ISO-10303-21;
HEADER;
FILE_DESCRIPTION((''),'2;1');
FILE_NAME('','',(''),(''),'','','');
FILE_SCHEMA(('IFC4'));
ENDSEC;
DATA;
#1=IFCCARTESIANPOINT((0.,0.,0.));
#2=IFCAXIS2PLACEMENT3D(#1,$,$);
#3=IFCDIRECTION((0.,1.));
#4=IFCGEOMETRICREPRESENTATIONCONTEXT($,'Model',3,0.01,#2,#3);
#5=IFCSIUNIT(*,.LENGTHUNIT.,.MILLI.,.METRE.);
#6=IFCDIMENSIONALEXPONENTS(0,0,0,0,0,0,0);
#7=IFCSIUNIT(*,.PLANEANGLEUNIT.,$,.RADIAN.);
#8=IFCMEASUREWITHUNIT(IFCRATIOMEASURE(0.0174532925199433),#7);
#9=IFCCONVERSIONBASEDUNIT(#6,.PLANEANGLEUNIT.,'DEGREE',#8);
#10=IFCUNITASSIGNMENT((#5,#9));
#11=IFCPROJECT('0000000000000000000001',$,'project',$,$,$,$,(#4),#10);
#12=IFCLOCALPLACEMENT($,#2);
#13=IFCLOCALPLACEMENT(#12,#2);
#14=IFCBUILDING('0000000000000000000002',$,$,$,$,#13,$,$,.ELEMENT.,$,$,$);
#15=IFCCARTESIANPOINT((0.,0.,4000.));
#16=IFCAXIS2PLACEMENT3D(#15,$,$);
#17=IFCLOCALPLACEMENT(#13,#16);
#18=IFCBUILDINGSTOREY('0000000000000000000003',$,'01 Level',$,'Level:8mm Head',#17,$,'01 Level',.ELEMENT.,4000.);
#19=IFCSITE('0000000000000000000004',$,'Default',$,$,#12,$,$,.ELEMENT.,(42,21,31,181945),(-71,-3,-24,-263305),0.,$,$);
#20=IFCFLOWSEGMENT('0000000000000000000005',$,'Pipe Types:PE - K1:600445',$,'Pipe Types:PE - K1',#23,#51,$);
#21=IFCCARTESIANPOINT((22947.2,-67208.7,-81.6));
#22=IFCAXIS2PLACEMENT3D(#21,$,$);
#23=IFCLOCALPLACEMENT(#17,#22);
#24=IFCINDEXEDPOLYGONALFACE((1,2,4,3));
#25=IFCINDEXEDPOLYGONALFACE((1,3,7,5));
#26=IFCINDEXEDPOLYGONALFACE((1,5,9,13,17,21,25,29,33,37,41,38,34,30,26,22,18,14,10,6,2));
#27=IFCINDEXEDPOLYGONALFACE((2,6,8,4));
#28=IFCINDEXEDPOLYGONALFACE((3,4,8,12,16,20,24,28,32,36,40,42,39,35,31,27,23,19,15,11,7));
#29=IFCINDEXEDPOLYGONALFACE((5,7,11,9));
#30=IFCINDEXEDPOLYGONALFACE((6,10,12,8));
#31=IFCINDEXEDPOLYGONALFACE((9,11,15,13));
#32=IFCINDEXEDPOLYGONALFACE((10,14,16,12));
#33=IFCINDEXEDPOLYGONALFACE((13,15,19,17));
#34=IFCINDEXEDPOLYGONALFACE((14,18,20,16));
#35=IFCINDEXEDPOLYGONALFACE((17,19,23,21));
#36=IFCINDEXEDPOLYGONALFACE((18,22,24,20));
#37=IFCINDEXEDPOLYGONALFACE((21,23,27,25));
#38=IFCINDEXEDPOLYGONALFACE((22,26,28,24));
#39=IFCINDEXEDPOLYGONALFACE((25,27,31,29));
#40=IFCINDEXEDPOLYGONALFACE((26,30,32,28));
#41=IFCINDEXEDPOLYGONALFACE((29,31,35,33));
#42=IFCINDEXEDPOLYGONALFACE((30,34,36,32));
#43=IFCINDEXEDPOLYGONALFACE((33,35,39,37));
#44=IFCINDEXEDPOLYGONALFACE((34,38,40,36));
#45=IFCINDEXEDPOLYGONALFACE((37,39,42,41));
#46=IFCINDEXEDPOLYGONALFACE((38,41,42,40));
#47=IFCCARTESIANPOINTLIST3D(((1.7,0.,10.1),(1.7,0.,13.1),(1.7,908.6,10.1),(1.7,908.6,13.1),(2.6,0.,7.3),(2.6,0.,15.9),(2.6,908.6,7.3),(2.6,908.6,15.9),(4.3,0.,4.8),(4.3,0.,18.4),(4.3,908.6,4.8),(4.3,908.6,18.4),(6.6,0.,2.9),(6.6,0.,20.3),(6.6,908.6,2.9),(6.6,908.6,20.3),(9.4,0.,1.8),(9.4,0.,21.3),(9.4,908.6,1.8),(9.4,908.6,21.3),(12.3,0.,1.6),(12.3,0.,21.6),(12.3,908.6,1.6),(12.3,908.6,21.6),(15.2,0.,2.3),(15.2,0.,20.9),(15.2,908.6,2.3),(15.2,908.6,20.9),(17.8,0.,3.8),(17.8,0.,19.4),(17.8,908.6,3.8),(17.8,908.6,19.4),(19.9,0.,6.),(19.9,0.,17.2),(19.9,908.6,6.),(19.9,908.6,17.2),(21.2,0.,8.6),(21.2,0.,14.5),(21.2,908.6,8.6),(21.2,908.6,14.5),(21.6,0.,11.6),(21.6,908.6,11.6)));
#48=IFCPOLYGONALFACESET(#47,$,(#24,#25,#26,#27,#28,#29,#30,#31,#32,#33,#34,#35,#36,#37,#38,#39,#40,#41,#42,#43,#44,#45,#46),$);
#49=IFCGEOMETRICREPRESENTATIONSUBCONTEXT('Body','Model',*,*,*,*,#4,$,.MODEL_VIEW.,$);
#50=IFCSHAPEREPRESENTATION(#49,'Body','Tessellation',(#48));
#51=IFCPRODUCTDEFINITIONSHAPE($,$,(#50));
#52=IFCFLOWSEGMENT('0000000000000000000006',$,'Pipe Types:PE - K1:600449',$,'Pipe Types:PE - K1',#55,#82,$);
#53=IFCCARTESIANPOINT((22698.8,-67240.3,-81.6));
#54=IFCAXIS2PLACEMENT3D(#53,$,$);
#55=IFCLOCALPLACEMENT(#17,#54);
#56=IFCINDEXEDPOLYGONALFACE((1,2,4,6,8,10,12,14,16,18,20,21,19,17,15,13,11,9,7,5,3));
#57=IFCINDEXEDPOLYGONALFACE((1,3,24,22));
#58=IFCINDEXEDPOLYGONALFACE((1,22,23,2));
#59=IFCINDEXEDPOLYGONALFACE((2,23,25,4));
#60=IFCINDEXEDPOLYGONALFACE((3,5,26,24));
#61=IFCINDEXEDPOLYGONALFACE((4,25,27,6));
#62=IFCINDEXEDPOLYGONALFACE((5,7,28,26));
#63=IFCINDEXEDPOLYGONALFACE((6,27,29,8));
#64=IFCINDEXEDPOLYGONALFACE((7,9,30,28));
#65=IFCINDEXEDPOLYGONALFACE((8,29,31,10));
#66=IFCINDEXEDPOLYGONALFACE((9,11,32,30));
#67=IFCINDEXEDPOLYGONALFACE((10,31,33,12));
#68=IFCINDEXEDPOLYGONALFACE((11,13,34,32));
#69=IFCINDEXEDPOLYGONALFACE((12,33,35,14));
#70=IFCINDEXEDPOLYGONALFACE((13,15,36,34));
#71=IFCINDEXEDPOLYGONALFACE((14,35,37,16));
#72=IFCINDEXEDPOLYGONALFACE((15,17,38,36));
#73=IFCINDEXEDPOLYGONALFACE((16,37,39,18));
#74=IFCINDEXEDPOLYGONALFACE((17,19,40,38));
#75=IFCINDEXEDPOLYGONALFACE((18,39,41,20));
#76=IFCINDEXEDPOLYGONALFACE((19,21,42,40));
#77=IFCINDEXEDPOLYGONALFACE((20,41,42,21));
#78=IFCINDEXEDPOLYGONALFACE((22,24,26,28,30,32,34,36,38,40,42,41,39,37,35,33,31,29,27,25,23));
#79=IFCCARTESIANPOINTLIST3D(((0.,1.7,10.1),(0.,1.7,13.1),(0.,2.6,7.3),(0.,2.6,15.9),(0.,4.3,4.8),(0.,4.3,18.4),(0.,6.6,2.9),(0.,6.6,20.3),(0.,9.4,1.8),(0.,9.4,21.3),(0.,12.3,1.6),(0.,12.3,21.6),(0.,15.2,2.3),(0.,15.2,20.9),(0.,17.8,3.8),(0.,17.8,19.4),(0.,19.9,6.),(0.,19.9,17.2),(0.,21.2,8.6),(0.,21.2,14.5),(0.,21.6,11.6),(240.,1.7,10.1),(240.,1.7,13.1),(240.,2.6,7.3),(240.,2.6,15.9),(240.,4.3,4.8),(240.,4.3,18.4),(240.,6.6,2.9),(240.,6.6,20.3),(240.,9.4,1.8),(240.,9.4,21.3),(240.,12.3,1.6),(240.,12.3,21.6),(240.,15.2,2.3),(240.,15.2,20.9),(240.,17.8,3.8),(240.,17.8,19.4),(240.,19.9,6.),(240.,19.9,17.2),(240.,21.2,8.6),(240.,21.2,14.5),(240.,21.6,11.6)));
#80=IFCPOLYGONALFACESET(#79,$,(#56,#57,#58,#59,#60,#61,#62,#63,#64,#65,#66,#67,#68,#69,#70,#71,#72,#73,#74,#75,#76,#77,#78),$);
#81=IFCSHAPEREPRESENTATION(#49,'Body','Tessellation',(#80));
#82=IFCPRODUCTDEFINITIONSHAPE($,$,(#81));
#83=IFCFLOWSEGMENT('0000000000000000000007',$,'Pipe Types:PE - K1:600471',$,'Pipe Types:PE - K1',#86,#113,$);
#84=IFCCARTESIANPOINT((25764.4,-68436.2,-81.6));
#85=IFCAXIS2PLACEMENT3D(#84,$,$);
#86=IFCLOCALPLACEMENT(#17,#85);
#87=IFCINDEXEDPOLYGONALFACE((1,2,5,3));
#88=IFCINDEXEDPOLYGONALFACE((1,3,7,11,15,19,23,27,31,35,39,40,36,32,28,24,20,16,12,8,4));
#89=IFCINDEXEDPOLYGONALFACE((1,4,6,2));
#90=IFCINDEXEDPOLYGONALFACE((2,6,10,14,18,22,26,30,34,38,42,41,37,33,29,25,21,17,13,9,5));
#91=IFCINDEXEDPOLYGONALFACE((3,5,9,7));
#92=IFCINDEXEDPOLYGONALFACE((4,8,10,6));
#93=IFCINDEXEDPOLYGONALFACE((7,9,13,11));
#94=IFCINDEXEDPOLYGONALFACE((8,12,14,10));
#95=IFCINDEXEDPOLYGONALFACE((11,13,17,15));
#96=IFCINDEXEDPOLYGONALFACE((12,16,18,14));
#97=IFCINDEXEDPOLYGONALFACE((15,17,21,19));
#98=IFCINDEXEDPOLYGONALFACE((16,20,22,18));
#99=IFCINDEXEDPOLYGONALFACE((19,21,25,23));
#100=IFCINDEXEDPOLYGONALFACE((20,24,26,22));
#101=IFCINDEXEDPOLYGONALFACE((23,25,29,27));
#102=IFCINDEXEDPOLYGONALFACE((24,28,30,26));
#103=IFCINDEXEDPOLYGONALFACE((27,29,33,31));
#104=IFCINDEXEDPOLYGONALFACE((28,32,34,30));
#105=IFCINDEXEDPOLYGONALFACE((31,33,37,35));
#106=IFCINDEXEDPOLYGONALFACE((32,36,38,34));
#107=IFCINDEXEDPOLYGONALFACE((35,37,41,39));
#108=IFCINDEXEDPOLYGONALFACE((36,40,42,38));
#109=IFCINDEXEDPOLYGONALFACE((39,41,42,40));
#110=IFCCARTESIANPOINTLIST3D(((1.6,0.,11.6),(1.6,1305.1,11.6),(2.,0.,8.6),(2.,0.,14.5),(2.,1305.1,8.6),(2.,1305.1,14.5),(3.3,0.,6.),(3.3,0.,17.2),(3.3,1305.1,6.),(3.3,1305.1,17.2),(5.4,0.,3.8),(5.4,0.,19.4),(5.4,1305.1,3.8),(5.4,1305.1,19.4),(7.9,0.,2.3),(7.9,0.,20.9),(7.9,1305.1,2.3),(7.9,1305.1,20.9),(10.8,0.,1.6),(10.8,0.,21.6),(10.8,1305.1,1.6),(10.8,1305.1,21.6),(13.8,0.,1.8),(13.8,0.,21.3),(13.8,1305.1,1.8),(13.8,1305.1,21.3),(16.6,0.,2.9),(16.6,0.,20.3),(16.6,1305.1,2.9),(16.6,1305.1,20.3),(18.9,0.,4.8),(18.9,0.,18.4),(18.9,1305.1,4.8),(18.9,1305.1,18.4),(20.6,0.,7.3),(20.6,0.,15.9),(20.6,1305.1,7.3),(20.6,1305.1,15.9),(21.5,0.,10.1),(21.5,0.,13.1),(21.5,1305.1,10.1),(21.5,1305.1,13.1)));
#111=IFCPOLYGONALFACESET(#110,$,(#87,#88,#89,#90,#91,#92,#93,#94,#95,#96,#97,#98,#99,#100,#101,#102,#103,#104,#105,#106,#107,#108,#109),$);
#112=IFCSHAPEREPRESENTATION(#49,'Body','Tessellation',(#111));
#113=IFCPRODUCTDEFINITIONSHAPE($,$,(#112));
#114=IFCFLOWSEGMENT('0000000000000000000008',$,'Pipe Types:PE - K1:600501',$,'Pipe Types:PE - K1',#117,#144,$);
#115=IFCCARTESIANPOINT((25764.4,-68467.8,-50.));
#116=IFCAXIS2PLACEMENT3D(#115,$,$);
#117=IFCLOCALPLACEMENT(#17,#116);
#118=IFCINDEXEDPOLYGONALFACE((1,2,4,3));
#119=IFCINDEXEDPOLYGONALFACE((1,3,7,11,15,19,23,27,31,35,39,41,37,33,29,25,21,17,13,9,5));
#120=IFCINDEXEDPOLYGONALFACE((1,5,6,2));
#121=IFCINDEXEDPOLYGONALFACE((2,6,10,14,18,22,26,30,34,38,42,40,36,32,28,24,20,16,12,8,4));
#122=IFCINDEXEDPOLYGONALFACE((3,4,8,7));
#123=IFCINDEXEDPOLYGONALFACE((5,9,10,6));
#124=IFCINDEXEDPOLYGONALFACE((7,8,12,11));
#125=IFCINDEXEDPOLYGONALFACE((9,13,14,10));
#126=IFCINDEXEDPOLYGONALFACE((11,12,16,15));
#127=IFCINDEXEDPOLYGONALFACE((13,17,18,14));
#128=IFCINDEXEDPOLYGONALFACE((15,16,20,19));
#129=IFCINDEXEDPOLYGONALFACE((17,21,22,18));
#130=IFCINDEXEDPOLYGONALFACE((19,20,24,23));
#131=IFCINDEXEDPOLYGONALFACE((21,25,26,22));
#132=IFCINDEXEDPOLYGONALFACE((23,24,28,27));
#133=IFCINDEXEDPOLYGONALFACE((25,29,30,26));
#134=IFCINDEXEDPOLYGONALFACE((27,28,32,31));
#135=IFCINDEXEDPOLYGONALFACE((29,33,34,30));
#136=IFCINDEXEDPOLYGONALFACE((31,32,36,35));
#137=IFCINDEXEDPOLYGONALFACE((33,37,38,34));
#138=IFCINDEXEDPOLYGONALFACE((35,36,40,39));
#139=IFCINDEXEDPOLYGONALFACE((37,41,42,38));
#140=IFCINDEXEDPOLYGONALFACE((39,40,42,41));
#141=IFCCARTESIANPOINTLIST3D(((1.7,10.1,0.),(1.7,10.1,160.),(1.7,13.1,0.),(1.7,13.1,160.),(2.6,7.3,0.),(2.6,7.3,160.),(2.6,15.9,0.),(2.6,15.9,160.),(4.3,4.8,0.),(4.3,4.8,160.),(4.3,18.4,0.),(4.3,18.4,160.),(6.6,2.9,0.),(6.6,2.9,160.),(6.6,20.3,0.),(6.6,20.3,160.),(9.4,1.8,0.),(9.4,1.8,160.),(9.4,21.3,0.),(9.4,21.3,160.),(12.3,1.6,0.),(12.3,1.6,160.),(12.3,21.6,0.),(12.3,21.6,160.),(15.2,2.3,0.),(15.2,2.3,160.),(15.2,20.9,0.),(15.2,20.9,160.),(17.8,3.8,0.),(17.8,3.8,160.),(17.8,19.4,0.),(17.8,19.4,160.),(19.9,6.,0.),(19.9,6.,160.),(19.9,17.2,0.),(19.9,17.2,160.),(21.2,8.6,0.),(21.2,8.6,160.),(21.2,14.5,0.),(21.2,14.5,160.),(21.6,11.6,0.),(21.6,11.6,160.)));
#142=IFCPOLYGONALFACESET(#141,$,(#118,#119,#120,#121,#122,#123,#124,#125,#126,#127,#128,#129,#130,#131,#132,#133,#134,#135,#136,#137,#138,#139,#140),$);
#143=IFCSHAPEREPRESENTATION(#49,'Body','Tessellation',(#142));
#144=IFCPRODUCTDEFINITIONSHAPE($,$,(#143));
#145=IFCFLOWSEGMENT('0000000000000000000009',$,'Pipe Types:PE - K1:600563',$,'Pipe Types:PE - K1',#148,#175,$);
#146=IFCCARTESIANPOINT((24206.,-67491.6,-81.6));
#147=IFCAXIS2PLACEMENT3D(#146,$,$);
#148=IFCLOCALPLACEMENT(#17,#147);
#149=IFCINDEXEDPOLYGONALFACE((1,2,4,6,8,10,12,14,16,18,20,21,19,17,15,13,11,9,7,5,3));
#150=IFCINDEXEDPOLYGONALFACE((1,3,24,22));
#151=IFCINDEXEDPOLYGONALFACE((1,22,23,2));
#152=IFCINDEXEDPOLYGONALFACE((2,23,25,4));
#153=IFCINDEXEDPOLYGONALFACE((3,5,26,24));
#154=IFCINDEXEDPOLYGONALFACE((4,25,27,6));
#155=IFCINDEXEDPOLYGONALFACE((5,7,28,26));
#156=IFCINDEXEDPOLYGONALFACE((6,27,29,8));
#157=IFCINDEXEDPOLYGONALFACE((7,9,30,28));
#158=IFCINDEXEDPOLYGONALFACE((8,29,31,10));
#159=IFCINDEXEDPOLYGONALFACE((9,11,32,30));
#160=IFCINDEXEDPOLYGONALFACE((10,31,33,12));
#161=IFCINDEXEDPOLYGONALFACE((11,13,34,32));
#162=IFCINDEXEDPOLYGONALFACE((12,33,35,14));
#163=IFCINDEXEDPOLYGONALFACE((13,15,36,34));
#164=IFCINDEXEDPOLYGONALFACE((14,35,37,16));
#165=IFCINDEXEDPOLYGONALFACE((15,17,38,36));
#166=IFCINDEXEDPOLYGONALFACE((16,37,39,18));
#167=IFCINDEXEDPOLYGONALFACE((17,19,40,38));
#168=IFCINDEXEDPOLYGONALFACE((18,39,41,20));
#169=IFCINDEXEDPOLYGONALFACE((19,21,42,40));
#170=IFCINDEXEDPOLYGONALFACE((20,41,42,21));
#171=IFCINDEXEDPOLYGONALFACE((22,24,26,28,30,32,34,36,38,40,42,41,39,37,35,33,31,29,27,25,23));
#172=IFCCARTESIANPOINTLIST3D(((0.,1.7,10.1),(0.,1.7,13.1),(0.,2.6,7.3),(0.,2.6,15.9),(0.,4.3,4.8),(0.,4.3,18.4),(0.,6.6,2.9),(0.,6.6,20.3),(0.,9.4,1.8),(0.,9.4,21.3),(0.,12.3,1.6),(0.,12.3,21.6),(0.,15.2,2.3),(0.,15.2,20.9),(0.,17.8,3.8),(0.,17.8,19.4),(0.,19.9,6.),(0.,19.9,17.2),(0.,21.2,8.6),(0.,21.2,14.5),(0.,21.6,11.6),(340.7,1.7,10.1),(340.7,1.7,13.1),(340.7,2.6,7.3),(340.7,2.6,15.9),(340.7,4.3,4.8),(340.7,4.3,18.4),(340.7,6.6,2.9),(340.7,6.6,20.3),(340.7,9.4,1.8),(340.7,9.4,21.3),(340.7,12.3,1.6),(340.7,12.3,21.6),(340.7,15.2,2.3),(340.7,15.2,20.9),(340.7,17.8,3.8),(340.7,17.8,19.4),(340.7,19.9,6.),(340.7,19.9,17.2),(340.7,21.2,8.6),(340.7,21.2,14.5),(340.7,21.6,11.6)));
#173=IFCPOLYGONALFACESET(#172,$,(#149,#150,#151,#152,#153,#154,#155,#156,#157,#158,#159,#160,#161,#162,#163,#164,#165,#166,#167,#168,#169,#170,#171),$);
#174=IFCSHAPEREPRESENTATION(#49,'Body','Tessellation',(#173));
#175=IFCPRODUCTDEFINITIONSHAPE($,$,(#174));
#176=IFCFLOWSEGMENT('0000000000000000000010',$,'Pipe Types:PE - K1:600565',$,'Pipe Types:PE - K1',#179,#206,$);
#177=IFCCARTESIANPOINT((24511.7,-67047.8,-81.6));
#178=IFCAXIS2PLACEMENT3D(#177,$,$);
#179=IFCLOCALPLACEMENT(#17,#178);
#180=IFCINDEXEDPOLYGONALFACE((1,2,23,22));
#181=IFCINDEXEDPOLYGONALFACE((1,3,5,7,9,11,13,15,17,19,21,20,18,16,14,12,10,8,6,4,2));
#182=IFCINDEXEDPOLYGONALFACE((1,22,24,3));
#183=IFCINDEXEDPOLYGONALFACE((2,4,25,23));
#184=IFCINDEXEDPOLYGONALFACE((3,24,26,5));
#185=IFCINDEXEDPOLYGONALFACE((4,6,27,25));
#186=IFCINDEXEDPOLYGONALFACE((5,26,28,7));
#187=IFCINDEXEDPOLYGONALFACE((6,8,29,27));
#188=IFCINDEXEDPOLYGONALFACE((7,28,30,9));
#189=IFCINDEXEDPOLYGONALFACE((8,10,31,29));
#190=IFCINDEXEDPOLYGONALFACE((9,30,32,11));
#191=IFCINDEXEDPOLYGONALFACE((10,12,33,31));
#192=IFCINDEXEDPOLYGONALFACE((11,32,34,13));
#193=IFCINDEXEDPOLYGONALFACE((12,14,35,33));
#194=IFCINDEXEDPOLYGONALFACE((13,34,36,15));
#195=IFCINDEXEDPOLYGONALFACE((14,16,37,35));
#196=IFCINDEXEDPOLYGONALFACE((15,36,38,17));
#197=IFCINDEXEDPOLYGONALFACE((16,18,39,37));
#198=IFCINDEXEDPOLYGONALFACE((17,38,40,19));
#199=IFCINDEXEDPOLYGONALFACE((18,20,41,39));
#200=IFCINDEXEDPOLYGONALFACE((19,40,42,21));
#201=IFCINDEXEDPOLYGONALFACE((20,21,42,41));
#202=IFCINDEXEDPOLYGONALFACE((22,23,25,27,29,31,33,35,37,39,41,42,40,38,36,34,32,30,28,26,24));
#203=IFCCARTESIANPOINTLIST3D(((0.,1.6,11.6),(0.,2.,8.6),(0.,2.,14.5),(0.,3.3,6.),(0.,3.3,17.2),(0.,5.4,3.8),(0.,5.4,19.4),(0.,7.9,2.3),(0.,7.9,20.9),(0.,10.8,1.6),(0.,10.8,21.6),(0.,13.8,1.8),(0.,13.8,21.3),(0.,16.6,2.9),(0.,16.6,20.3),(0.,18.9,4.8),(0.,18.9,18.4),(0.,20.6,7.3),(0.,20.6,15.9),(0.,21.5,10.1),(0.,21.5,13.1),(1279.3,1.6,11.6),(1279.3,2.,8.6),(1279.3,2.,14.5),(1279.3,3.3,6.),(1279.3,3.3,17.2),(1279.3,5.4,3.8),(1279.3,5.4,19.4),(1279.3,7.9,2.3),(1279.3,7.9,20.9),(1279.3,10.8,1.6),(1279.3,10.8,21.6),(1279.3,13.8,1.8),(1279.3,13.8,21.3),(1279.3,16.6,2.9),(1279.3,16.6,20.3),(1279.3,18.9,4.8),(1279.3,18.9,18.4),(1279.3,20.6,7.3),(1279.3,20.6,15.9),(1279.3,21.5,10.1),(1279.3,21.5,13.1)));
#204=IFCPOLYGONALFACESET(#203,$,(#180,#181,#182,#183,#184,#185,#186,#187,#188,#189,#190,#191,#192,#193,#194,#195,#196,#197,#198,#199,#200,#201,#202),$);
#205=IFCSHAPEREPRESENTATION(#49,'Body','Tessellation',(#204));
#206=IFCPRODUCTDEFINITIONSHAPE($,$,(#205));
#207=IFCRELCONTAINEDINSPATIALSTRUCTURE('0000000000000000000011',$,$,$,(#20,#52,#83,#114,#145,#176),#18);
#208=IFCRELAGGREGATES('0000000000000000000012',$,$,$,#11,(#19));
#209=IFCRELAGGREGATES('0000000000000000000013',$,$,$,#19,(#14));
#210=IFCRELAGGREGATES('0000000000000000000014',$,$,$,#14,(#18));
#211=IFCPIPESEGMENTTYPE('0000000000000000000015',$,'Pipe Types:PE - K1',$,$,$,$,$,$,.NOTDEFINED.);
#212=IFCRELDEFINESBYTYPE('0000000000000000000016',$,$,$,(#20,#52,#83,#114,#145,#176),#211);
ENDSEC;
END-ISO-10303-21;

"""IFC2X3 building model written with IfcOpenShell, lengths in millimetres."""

from ifc_helpers import new_model, entity, si_unit, converted_unit, direction, frame, frame_2d, origin, origin_2d_with_axis, place, context, subcontext, project, spatial, circle, extrude, type_object, element, save


model = new_model("IFC2X3")

# Units and contexts
model_context = context("Model", 3, precision=0.01, world=origin(), true_north=direction((0.0, 1.0)))
body_context = subcontext(model_context, "Body", "Model", "MODEL_VIEW")
ifc_project = project(units=[si_unit("LENGTHUNIT", "METRE", prefix="MILLI"), converted_unit("PLANEANGLEUNIT", "DEGREE", entity("IfcRatioMeasure", 0.0174532925199433), si_unit("PLANEANGLEUNIT", "RADIAN"), dimensions=[0, 0, 0, 0, 0, 0, 0])], contexts=[model_context])

# Site, building, storey
site_placement = place(None, origin())
site = spatial("IfcSite", under=ifc_project, at=site_placement, Name="Default", CompositionType="ELEMENT", RefLatitude=(42, 21, 31, 181945), RefLongitude=(-71, -3, -24, -263305), RefElevation=0.0)
building_placement = place(site_placement, origin())
building = spatial("IfcBuilding", under=site, at=building_placement, CompositionType="ELEMENT")
storey_placement = place(building_placement, frame((0.0, 0.0, 4000.0)))
storey = spatial("IfcBuildingStorey", under=building, at=storey_placement, Name="01 Level", ObjectType="Level:8mm Head", LongName="01 Level", CompositionType="ELEMENT", Elevation=4000.0)

# Flow segments
pipe_segment_type = type_object("IfcPipeSegmentType", Name="Pipe Types:PE - K1", PredefinedType="NOTDEFINED")
flow_segment_1_placement = place(storey_placement, frame((22947.2, -67208.7, -81.6)))
element("IfcFlowSegment", 1, at=flow_segment_1_placement, inside=storey, type_object=pipe_segment_type, Name="Pipe Types:PE - K1:600445", ObjectType="Pipe Types:PE - K1", context=body_context, shape_type="SweptSolid", body=[
    extrude(circle(Radius=10.0, at=origin_2d_with_axis()), frame((11.6, 0.0, 11.6), z_axis=(0.0, 1.0, 0.0), x_axis=(1.0, 0.0, 0.0)), (0.0, 0.0, 1.0), 908.6),
])
flow_segment_2_placement = place(storey_placement, frame((22698.8, -67240.3, -81.6)))
element("IfcFlowSegment", 2, at=flow_segment_2_placement, inside=storey, type_object=pipe_segment_type, Name="Pipe Types:PE - K1:600449", ObjectType="Pipe Types:PE - K1", context=body_context, shape_type="SweptSolid", body=[
    extrude(circle(Radius=10.0, at=origin_2d_with_axis()), frame((0.0, 11.6, 11.6), z_axis=(1.0, 0.0, 0.0), x_axis=(0.0, 1.0, 0.0)), (0.0, 0.0, 1.0), 240.0),
])
flow_segment_3_placement = place(storey_placement, frame((25764.4, -68436.2, -81.6)))
element("IfcFlowSegment", 3, at=flow_segment_3_placement, inside=storey, type_object=pipe_segment_type, Name="Pipe Types:PE - K1:600471", ObjectType="Pipe Types:PE - K1", context=body_context, shape_type="SweptSolid", body=[
    extrude(circle(Radius=10.0, at=origin_2d_with_axis()), frame((11.6, 0.0, 11.6), z_axis=(0.0, 1.0, 0.0), x_axis=(-1.0, 0.0, 0.0)), (0.0, 0.0, 1.0), 1305.1),
])
flow_segment_4_placement = place(storey_placement, frame((25764.4, -68467.8, -50.0)))
element("IfcFlowSegment", 4, at=flow_segment_4_placement, inside=storey, type_object=pipe_segment_type, Name="Pipe Types:PE - K1:600501", ObjectType="Pipe Types:PE - K1", context=body_context, shape_type="SweptSolid", body=[
    extrude(circle(Radius=10.0, at=origin_2d_with_axis()), frame((11.6, 11.6, 0.0)), (0.0, 0.0, 1.0), 160.0),
])
flow_segment_5_placement = place(storey_placement, frame((24206.0, -67491.6, -81.6)))
element("IfcFlowSegment", 5, at=flow_segment_5_placement, inside=storey, type_object=pipe_segment_type, Name="Pipe Types:PE - K1:600563", ObjectType="Pipe Types:PE - K1", context=body_context, shape_type="SweptSolid", body=[
    extrude(circle(Radius=10.0, at=frame_2d((0.0, 0.0), x_axis=(1.0, 0.0))), frame((0.0, 11.6, 11.6), z_axis=(1.0, 0.0, 0.0), x_axis=(0.0, 1.0, 0.0)), (0.0, 0.0, 1.0), 340.7),
])
flow_segment_6_placement = place(storey_placement, frame((24511.7, -67047.8, -81.6)))
element("IfcFlowSegment", 6, at=flow_segment_6_placement, inside=storey, type_object=pipe_segment_type, Name="Pipe Types:PE - K1:600565", ObjectType="Pipe Types:PE - K1", context=body_context, shape_type="SweptSolid", body=[
    extrude(circle(Radius=10.0, at=origin_2d_with_axis()), frame((0.0, 11.6, 11.6), z_axis=(1.0, 0.0, 0.0), x_axis=(0.0, -1.0, 0.0)), (0.0, 0.0, 1.0), 1279.3),
])

save(model, "model.ifc")
